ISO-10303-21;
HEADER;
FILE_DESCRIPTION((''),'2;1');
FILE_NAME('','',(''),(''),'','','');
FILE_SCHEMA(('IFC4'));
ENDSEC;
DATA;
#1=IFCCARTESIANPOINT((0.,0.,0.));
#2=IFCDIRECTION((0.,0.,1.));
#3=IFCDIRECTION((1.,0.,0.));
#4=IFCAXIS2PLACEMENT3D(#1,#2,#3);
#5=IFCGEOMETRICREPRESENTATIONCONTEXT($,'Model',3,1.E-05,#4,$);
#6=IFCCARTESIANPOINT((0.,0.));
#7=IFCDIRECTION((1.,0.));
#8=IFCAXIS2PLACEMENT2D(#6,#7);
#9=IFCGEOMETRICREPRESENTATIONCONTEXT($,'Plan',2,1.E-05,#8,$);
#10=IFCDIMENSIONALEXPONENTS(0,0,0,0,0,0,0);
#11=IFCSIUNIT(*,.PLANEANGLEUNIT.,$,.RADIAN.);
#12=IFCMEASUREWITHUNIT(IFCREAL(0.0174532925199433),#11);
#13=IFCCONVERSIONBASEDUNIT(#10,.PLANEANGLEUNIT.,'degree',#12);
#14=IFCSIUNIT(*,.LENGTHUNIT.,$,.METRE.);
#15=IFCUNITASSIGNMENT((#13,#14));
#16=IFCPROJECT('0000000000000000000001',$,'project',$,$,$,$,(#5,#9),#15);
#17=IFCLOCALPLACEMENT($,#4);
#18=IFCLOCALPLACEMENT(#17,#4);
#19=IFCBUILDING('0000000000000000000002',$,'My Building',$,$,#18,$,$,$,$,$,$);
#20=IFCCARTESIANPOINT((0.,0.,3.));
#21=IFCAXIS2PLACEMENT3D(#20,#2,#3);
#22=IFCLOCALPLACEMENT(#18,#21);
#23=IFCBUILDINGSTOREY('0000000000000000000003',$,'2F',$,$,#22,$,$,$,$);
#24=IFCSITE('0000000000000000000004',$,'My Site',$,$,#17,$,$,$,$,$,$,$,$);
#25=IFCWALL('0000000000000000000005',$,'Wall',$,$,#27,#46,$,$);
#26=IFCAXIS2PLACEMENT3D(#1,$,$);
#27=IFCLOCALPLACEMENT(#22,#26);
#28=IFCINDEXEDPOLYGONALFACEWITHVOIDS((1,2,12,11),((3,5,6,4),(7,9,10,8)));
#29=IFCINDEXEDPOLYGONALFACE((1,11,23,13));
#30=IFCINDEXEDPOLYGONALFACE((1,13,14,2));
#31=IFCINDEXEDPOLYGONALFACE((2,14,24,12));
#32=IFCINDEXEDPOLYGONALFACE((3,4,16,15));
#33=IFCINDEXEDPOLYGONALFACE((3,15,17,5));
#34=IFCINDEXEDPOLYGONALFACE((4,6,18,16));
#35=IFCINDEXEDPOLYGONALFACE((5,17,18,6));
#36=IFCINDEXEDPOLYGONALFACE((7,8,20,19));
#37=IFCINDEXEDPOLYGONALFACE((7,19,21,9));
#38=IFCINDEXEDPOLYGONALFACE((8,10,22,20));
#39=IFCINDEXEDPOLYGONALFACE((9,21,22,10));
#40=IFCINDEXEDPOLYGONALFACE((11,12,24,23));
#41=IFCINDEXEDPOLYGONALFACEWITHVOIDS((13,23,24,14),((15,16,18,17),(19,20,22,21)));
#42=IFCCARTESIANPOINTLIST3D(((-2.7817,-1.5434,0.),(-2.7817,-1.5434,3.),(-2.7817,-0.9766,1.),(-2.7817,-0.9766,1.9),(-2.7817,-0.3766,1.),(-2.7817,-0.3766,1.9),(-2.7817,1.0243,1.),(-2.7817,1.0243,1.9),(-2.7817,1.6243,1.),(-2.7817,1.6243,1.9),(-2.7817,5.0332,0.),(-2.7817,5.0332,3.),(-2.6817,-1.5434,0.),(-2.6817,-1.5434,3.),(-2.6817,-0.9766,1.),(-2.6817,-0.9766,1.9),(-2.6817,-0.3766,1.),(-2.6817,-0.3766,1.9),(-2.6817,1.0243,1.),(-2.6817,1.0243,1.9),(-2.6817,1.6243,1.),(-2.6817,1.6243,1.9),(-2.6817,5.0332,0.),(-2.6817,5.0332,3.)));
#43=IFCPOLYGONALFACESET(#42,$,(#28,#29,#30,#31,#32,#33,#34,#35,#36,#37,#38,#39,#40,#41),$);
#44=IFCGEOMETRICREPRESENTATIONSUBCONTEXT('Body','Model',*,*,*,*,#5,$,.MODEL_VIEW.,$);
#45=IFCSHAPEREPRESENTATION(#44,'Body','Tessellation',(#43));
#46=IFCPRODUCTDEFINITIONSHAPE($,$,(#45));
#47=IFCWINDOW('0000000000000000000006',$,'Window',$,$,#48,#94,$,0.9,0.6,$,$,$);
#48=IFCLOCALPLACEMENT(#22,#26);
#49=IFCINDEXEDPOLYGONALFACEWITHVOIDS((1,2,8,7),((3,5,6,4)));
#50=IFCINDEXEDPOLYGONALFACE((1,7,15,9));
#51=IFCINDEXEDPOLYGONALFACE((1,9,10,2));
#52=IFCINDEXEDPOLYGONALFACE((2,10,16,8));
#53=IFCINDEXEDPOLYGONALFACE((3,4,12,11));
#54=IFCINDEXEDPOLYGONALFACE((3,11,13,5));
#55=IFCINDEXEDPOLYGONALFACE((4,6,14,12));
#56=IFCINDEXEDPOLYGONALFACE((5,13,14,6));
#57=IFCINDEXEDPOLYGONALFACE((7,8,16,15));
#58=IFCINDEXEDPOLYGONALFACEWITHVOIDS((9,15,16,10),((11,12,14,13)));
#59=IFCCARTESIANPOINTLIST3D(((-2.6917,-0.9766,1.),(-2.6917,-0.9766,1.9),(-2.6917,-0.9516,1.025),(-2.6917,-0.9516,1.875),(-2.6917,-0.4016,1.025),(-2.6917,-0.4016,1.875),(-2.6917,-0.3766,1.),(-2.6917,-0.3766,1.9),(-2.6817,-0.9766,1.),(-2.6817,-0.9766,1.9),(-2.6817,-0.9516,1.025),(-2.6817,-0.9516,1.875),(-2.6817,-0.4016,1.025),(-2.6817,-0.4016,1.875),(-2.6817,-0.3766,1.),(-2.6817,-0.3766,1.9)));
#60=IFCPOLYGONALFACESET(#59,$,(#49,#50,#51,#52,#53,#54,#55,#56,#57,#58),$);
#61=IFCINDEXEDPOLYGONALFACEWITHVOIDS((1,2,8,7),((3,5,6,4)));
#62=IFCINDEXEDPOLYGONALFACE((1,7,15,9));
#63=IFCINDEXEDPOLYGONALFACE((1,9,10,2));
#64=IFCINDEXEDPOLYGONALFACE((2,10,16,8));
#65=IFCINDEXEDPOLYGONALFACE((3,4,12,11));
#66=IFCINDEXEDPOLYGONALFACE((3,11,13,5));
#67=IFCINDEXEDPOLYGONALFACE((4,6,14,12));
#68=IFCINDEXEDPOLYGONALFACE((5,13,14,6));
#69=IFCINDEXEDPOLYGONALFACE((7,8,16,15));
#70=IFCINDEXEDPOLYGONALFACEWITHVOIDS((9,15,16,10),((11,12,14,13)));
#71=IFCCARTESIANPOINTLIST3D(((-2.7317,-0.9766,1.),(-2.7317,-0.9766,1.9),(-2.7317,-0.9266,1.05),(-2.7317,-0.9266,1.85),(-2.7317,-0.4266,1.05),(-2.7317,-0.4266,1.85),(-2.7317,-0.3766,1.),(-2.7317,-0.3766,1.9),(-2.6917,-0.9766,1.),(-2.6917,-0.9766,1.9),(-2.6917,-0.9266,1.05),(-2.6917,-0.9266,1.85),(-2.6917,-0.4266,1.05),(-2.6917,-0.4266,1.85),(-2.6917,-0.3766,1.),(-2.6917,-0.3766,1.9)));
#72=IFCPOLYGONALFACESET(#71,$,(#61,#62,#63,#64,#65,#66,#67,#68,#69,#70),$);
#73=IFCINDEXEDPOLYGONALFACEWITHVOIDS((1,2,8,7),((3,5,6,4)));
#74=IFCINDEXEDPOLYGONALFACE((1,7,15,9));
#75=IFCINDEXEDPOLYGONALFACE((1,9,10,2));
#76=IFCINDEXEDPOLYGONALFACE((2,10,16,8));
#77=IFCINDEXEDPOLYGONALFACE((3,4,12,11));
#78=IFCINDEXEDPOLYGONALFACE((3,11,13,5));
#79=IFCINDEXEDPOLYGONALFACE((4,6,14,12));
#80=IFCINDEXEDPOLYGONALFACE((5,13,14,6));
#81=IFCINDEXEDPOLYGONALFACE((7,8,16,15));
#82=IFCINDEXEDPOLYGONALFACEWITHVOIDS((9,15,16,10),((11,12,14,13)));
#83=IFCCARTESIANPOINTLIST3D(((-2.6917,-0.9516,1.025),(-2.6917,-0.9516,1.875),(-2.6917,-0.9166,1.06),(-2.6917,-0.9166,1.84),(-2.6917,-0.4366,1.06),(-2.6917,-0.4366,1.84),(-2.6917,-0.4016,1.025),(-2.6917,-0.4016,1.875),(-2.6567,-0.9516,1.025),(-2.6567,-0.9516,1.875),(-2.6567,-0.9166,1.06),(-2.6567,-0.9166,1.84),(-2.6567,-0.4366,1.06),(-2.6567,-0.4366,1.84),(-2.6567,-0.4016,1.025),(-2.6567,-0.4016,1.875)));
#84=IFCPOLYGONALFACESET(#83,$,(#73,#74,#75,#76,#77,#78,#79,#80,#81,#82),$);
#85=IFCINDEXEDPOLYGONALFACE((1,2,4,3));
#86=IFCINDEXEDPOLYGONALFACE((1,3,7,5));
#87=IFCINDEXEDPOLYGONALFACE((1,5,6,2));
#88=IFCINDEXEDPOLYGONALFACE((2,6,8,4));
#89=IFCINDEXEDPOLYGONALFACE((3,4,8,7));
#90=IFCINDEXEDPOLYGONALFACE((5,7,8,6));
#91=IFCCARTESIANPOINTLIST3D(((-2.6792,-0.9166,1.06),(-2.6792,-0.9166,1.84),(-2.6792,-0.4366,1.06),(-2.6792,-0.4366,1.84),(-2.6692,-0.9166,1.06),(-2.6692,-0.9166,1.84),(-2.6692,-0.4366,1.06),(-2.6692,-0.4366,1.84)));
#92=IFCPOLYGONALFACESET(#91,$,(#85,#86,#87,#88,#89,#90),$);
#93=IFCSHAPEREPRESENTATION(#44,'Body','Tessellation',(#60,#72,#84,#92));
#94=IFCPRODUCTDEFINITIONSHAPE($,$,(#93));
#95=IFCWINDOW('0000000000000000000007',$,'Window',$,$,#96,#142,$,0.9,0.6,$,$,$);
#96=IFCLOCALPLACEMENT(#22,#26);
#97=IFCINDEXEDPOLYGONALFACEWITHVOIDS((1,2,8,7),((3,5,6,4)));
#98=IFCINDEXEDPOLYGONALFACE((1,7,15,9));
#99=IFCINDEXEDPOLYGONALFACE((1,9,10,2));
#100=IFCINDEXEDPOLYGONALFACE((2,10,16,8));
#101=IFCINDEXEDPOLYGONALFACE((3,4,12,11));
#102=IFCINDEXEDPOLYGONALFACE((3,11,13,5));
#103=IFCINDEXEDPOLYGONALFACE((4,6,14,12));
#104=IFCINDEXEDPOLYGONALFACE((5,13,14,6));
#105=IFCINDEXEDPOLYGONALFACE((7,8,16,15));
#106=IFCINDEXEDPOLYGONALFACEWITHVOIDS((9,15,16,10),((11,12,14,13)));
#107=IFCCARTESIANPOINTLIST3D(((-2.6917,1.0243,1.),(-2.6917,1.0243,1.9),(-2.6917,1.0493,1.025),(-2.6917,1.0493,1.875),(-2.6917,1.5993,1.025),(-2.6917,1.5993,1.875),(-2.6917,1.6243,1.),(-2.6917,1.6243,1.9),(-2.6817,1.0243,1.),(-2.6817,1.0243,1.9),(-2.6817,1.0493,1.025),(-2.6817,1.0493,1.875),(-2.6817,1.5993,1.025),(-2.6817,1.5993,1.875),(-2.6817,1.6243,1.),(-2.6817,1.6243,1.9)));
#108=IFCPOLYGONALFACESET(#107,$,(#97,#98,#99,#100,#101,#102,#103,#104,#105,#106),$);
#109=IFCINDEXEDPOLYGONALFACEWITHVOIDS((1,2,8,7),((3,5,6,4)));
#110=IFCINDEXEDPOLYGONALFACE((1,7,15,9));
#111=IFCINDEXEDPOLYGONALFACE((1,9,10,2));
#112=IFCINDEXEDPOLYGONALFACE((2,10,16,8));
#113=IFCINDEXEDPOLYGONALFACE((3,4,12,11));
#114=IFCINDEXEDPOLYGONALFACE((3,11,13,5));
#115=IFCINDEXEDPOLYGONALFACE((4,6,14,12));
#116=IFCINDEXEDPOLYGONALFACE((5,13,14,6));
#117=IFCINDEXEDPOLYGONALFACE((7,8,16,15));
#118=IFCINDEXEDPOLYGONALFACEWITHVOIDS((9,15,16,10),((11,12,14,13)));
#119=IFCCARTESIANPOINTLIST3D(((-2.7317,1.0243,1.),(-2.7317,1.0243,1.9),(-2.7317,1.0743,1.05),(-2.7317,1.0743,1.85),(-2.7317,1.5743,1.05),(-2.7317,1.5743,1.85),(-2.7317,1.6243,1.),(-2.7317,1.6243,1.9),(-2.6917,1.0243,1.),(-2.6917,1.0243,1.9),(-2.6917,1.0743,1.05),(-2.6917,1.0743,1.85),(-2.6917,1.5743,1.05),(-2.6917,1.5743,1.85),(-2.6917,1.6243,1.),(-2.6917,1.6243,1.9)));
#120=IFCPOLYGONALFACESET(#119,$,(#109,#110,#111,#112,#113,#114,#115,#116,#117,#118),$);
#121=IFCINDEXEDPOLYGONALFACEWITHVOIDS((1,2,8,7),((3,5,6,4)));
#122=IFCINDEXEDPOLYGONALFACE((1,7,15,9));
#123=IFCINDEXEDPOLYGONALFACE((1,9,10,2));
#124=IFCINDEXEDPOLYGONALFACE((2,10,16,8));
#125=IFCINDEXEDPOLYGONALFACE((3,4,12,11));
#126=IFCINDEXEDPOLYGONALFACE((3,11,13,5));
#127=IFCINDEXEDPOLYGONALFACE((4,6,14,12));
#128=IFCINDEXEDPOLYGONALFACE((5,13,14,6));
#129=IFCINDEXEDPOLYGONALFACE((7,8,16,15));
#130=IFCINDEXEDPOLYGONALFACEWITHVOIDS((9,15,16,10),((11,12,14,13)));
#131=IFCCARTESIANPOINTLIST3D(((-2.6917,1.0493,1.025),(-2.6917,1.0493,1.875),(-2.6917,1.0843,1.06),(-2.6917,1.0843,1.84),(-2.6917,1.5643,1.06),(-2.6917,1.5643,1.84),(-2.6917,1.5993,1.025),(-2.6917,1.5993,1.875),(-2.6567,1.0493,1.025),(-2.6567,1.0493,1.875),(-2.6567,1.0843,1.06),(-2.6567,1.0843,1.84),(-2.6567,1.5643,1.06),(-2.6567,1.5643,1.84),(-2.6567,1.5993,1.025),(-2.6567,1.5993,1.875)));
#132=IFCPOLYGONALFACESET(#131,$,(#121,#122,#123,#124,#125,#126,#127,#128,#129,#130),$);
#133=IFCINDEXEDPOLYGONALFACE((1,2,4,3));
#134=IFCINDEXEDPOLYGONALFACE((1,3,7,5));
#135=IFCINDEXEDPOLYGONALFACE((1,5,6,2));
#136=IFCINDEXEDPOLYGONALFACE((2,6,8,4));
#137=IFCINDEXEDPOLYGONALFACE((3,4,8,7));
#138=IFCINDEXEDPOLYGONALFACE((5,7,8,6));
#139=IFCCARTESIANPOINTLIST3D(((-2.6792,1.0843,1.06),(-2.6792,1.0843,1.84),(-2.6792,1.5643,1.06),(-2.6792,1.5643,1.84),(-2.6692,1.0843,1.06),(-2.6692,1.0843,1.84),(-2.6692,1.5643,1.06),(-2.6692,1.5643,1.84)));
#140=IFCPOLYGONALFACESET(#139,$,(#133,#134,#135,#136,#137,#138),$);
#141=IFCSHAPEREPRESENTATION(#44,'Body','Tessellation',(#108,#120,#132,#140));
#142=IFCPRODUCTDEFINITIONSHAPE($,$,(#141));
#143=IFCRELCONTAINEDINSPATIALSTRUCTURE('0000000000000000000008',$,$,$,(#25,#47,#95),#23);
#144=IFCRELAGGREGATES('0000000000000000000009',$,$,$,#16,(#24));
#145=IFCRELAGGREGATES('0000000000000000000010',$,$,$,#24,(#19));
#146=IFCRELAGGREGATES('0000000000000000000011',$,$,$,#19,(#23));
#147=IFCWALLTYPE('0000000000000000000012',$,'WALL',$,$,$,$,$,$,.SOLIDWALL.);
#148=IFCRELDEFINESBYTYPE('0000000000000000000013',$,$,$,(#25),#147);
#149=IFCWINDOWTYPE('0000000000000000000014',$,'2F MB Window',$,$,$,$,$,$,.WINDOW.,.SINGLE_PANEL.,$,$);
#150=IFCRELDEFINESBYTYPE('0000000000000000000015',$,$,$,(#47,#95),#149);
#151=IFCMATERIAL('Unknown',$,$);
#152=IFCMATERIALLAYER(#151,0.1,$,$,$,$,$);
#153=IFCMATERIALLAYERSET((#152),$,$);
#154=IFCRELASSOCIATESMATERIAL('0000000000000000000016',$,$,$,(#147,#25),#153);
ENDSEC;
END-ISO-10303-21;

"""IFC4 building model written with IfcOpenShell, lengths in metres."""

from ifc_helpers import new_model, entity, si_unit, converted_unit, frame, origin_with_axes, origin_2d_with_axis, place, context, subcontext, project, spatial, line, indexed_curve, outline, extrude, shape, source, transform, mapped, material, layer, layer_set, layer_usage, type_object, type_shapes, element, fill, save


model = new_model("IFC4")

# Units and contexts
model_context = context("Model", 3, precision=1e-05, world=origin_with_axes())
plan_context = context("Plan", 2, precision=1e-05, world=origin_2d_with_axis())
body_context_1 = subcontext(model_context, "Body", "Model", "MODEL_VIEW")
body_context_2 = subcontext(plan_context, "Body", "Plan", "PLAN_VIEW")
ifc_project = project(units=[converted_unit("PLANEANGLEUNIT", "degree", entity("IfcReal", 0.0174532925199433), si_unit("PLANEANGLEUNIT", "RADIAN"), dimensions=[0, 0, 0, 0, 0, 0, 0]), si_unit("LENGTHUNIT", "METRE")], contexts=[model_context, plan_context])

# Site, building, storey
site_placement = place(None, origin_with_axes())
site = spatial("IfcSite", under=ifc_project, at=site_placement, Name="My Site")
building_placement = place(site_placement, origin_with_axes())
building = spatial("IfcBuilding", under=site, at=building_placement, Name="My Building")
storey_placement = place(building_placement, frame((0.0, 0.0, 3.0), z_axis=(0.0, 0.0, 1.0), x_axis=(1.0, 0.0, 0.0)))
storey = spatial("IfcBuildingStorey", under=building, at=storey_placement, Name="2F")

# Shared definitions
ifc_material = material(Name="Unknown")

# Shared definitions
ifc_layer_1 = layer(ifc_material, 0.1)
ifc_layer_set_1 = layer_set([ifc_layer_1])
wall_type = type_object("IfcWallType", Name="WALL", PredefinedType="SOLIDWALL", material=ifc_layer_set_1)

# Wall, openings, windows
ifc_layer_usage_1 = layer_usage(ifc_layer_set_1, "AXIS2", "POSITIVE", 0.0)
wall_1_placement = place(storey_placement, frame((-2.7817, 5.0332, 0.0), z_axis=(0.0, 0.0, 1.0), x_axis=(0.000004, -1.0, 0.0)))
wall_1 = element("IfcWall", 1, at=wall_1_placement, inside=storey, type_object=wall_type, material=ifc_layer_usage_1, Name="Wall", context=body_context_1, shape_type="SweptSolid", body=[
    extrude(outline(indexed_curve([(0.0, 0.0), (0.0, 0.1), (6.5766, 0.1), (6.5766, 0.0)], segments=[line(1, 2, 3, 4, 1)])), origin_with_axes(), (0.0, 0.0, 1.0), 3.0),
])
shared_shape_1 = source(origin_with_axes(), body_context_1, "Body", "SweptSolid", [
    extrude(outline(indexed_curve([(0.0, 0.0), (0.6, 0.0), (0.6, 0.9), (0.0, 0.9)], segments=[line(1, 2, 3, 4, 1)])), frame((0.0, -0.6, 0.0), z_axis=(0.0, -1.0, 0.0), x_axis=(1.0, 0.0, 0.0)), (0.0, 0.0, -1.0), 1.2),
])
opening_1_placement = place(wall_1_placement, frame((5.4098, 0.0, 1.0), z_axis=(0.0, 0.0, 1.0), x_axis=(1.0, 0.0, 0.0)))
opening_1 = element("IfcOpeningElement", 2, at=opening_1_placement, cuts=wall_1, PredefinedType="OPENING", context=body_context_1, shape_type="MappedRepresentation", body=[
    mapped(shared_shape_1, transform((0.0, 0.0, 0.0), x_axis=(1.0, 0.0, 0.0), y_axis=(0.0, 1.0, 0.0), z_axis=(0.0, 0.0, 1.0), scale=1.0)),
])
opening_2_placement = place(wall_1_placement, frame((3.4089, 0.0, 1.0), z_axis=(0.0, 0.0, 1.0), x_axis=(1.0, 0.0, 0.0)))
opening_2 = element("IfcOpeningElement", 3, at=opening_2_placement, cuts=wall_1, PredefinedType="OPENING", context=body_context_1, shape_type="MappedRepresentation", body=[
    mapped(shared_shape_1, transform((0.0, 0.0, 0.0), x_axis=(1.0, 0.0, 0.0), y_axis=(0.0, 1.0, 0.0), z_axis=(0.0, 0.0, 1.0), scale=1.0)),
])
window_type_1 = type_object("IfcWindowType", Name="2F MB Window", PartitioningType="SINGLE_PANEL", PredefinedType="WINDOW")
shared_shape_2 = source(origin_with_axes(), body_context_1, "Body", "SweptSolid", [
    extrude(outline(indexed_curve([(0.0, 0.0), (0.6, 0.0), (0.6, 0.9), (0.0, 0.9)], segments=[line(1, 2, 3, 4, 1)]), holes=[indexed_curve([(0.025, 0.025), (0.575, 0.025), (0.575, 0.875), (0.025, 0.875)], segments=[line(1, 2, 3, 4, 1)])]), frame((0.0, 0.09, 0.0), z_axis=(0.0, -1.0, 0.0), x_axis=(1.0, 0.0, 0.0)), (0.0, 0.0, -1.0), 0.01),
    extrude(outline(indexed_curve([(0.0, 0.0), (0.6, 0.0), (0.6, 0.9), (0.0, 0.9)], segments=[line(1, 2, 3, 4, 1)]), holes=[indexed_curve([(0.05, 0.05), (0.55, 0.05), (0.55, 0.85), (0.05, 0.85)], segments=[line(1, 2, 3, 4, 1)])]), frame((0.0, 0.05, 0.0), z_axis=(0.0, -1.0, 0.0), x_axis=(1.0, 0.0, 0.0)), (0.0, 0.0, -1.0), 0.04),
    extrude(outline(indexed_curve([(0.0, 0.0), (0.55, 0.0), (0.55, 0.85), (0.0, 0.85)], segments=[line(1, 2, 3, 4, 1)]), holes=[indexed_curve([(0.035, 0.035), (0.515, 0.035), (0.515, 0.815), (0.035, 0.815)], segments=[line(1, 2, 3, 4, 1)])]), frame((0.025, 0.09, 0.025), z_axis=(0.0, -1.0, 0.0), x_axis=(1.0, 0.0, 0.0)), (0.0, 0.0, -1.0), 0.035),
    extrude(outline(indexed_curve([(0.035, 0.035), (0.515, 0.035), (0.515, 0.815), (0.035, 0.815)], segments=[line(1, 2, 3, 4, 1)])), frame((0.025, 0.1025, 0.025), z_axis=(0.0, -1.0, 0.0), x_axis=(1.0, 0.0, 0.0)), (0.0, 0.0, -1.0), 0.01),
])
shared_shape_3 = source(origin_with_axes(), body_context_2, "Body", "Curve2D", [
    entity("IfcIndexedPolyCurve", entity("IfcCartesianPointList2D", [[0.05, 0.05], [0.55, 0.05]])),
    entity("IfcIndexedPolyCurve", entity("IfcCartesianPointList2D", [[0.0, 0.1], [0.025, 0.1], [0.025, 0.09], [0.05, 0.09], [0.05, 0.05], [0.0, 0.05]]), [entity("IfcLineIndex", [1, 2, 3, 4, 5, 6, 1])]),
    entity("IfcIndexedPolyCurve", entity("IfcCartesianPointList2D", [[0.6, 0.1], [0.575, 0.1], [0.575, 0.09], [0.55, 0.09], [0.55, 0.05], [0.6, 0.05]]), [entity("IfcLineIndex", [1, 2, 3, 4, 5, 6, 1])]),
    entity("IfcIndexedPolyCurve", entity("IfcCartesianPointList2D", [[0.025, 0.09], [0.06, 0.09], [0.06, 0.125], [0.025, 0.125]]), [entity("IfcLineIndex", [1, 2, 3, 4, 1])]),
    entity("IfcIndexedPolyCurve", entity("IfcCartesianPointList2D", [[0.575, 0.09], [0.54, 0.09], [0.54, 0.125], [0.575, 0.125]]), [entity("IfcLineIndex", [1, 2, 3, 4, 1])]),
    entity("IfcIndexedPolyCurve", entity("IfcCartesianPointList2D", [[0.06, 0.09], [0.54, 0.09]])),
    entity("IfcIndexedPolyCurve", entity("IfcCartesianPointList2D", [[0.06, 0.125], [0.54, 0.125]])),
    entity("IfcIndexedPolyCurve", entity("IfcCartesianPointList2D", [[0.06, 0.1075], [0.54, 0.1075]])),
])
type_shapes(window_type_1, [shared_shape_2, shared_shape_3])
window_1_placement = place(opening_1_placement, origin_with_axes())
window_1 = element("IfcWindow", 4, at=window_1_placement, inside=storey, type_object=window_type_1, Name="Window", OverallHeight=0.9, OverallWidth=0.6, shapes=[
    shape(body_context_1, "Body", "MappedRepresentation", [mapped(shared_shape_2, transform((0.0, 0.0, 0.0), x_axis=(1.0, 0.0, 0.0), y_axis=(0.0, 1.0, 0.0), z_axis=(0.0, 0.0, 1.0), scale=1.0))]),
    shape(body_context_2, "Body", "MappedRepresentation", [mapped(shared_shape_3, transform((0.0, 0.0, 0.0), x_axis=(1.0, 0.0, 0.0), y_axis=(0.0, 1.0, 0.0), z_axis=(0.0, 0.0, 1.0), scale=1.0))]),
])
fill(opening_1, window_1)
window_2_placement = place(opening_2_placement, origin_with_axes())
window_2 = element("IfcWindow", 5, at=window_2_placement, inside=storey, type_object=window_type_1, Name="Window", OverallHeight=0.9, OverallWidth=0.6, shapes=[
    shape(body_context_1, "Body", "MappedRepresentation", [mapped(shared_shape_2, transform((0.0, 0.0, 0.0), x_axis=(1.0, 0.0, 0.0), y_axis=(0.0, 1.0, 0.0), z_axis=(0.0, 0.0, 1.0), scale=1.0))]),
    shape(body_context_2, "Body", "MappedRepresentation", [mapped(shared_shape_3, transform((0.0, 0.0, 0.0), x_axis=(1.0, 0.0, 0.0), y_axis=(0.0, 1.0, 0.0), z_axis=(0.0, 0.0, 1.0), scale=1.0))]),
])
fill(opening_2, window_2)

save(model, "model.ifc")
